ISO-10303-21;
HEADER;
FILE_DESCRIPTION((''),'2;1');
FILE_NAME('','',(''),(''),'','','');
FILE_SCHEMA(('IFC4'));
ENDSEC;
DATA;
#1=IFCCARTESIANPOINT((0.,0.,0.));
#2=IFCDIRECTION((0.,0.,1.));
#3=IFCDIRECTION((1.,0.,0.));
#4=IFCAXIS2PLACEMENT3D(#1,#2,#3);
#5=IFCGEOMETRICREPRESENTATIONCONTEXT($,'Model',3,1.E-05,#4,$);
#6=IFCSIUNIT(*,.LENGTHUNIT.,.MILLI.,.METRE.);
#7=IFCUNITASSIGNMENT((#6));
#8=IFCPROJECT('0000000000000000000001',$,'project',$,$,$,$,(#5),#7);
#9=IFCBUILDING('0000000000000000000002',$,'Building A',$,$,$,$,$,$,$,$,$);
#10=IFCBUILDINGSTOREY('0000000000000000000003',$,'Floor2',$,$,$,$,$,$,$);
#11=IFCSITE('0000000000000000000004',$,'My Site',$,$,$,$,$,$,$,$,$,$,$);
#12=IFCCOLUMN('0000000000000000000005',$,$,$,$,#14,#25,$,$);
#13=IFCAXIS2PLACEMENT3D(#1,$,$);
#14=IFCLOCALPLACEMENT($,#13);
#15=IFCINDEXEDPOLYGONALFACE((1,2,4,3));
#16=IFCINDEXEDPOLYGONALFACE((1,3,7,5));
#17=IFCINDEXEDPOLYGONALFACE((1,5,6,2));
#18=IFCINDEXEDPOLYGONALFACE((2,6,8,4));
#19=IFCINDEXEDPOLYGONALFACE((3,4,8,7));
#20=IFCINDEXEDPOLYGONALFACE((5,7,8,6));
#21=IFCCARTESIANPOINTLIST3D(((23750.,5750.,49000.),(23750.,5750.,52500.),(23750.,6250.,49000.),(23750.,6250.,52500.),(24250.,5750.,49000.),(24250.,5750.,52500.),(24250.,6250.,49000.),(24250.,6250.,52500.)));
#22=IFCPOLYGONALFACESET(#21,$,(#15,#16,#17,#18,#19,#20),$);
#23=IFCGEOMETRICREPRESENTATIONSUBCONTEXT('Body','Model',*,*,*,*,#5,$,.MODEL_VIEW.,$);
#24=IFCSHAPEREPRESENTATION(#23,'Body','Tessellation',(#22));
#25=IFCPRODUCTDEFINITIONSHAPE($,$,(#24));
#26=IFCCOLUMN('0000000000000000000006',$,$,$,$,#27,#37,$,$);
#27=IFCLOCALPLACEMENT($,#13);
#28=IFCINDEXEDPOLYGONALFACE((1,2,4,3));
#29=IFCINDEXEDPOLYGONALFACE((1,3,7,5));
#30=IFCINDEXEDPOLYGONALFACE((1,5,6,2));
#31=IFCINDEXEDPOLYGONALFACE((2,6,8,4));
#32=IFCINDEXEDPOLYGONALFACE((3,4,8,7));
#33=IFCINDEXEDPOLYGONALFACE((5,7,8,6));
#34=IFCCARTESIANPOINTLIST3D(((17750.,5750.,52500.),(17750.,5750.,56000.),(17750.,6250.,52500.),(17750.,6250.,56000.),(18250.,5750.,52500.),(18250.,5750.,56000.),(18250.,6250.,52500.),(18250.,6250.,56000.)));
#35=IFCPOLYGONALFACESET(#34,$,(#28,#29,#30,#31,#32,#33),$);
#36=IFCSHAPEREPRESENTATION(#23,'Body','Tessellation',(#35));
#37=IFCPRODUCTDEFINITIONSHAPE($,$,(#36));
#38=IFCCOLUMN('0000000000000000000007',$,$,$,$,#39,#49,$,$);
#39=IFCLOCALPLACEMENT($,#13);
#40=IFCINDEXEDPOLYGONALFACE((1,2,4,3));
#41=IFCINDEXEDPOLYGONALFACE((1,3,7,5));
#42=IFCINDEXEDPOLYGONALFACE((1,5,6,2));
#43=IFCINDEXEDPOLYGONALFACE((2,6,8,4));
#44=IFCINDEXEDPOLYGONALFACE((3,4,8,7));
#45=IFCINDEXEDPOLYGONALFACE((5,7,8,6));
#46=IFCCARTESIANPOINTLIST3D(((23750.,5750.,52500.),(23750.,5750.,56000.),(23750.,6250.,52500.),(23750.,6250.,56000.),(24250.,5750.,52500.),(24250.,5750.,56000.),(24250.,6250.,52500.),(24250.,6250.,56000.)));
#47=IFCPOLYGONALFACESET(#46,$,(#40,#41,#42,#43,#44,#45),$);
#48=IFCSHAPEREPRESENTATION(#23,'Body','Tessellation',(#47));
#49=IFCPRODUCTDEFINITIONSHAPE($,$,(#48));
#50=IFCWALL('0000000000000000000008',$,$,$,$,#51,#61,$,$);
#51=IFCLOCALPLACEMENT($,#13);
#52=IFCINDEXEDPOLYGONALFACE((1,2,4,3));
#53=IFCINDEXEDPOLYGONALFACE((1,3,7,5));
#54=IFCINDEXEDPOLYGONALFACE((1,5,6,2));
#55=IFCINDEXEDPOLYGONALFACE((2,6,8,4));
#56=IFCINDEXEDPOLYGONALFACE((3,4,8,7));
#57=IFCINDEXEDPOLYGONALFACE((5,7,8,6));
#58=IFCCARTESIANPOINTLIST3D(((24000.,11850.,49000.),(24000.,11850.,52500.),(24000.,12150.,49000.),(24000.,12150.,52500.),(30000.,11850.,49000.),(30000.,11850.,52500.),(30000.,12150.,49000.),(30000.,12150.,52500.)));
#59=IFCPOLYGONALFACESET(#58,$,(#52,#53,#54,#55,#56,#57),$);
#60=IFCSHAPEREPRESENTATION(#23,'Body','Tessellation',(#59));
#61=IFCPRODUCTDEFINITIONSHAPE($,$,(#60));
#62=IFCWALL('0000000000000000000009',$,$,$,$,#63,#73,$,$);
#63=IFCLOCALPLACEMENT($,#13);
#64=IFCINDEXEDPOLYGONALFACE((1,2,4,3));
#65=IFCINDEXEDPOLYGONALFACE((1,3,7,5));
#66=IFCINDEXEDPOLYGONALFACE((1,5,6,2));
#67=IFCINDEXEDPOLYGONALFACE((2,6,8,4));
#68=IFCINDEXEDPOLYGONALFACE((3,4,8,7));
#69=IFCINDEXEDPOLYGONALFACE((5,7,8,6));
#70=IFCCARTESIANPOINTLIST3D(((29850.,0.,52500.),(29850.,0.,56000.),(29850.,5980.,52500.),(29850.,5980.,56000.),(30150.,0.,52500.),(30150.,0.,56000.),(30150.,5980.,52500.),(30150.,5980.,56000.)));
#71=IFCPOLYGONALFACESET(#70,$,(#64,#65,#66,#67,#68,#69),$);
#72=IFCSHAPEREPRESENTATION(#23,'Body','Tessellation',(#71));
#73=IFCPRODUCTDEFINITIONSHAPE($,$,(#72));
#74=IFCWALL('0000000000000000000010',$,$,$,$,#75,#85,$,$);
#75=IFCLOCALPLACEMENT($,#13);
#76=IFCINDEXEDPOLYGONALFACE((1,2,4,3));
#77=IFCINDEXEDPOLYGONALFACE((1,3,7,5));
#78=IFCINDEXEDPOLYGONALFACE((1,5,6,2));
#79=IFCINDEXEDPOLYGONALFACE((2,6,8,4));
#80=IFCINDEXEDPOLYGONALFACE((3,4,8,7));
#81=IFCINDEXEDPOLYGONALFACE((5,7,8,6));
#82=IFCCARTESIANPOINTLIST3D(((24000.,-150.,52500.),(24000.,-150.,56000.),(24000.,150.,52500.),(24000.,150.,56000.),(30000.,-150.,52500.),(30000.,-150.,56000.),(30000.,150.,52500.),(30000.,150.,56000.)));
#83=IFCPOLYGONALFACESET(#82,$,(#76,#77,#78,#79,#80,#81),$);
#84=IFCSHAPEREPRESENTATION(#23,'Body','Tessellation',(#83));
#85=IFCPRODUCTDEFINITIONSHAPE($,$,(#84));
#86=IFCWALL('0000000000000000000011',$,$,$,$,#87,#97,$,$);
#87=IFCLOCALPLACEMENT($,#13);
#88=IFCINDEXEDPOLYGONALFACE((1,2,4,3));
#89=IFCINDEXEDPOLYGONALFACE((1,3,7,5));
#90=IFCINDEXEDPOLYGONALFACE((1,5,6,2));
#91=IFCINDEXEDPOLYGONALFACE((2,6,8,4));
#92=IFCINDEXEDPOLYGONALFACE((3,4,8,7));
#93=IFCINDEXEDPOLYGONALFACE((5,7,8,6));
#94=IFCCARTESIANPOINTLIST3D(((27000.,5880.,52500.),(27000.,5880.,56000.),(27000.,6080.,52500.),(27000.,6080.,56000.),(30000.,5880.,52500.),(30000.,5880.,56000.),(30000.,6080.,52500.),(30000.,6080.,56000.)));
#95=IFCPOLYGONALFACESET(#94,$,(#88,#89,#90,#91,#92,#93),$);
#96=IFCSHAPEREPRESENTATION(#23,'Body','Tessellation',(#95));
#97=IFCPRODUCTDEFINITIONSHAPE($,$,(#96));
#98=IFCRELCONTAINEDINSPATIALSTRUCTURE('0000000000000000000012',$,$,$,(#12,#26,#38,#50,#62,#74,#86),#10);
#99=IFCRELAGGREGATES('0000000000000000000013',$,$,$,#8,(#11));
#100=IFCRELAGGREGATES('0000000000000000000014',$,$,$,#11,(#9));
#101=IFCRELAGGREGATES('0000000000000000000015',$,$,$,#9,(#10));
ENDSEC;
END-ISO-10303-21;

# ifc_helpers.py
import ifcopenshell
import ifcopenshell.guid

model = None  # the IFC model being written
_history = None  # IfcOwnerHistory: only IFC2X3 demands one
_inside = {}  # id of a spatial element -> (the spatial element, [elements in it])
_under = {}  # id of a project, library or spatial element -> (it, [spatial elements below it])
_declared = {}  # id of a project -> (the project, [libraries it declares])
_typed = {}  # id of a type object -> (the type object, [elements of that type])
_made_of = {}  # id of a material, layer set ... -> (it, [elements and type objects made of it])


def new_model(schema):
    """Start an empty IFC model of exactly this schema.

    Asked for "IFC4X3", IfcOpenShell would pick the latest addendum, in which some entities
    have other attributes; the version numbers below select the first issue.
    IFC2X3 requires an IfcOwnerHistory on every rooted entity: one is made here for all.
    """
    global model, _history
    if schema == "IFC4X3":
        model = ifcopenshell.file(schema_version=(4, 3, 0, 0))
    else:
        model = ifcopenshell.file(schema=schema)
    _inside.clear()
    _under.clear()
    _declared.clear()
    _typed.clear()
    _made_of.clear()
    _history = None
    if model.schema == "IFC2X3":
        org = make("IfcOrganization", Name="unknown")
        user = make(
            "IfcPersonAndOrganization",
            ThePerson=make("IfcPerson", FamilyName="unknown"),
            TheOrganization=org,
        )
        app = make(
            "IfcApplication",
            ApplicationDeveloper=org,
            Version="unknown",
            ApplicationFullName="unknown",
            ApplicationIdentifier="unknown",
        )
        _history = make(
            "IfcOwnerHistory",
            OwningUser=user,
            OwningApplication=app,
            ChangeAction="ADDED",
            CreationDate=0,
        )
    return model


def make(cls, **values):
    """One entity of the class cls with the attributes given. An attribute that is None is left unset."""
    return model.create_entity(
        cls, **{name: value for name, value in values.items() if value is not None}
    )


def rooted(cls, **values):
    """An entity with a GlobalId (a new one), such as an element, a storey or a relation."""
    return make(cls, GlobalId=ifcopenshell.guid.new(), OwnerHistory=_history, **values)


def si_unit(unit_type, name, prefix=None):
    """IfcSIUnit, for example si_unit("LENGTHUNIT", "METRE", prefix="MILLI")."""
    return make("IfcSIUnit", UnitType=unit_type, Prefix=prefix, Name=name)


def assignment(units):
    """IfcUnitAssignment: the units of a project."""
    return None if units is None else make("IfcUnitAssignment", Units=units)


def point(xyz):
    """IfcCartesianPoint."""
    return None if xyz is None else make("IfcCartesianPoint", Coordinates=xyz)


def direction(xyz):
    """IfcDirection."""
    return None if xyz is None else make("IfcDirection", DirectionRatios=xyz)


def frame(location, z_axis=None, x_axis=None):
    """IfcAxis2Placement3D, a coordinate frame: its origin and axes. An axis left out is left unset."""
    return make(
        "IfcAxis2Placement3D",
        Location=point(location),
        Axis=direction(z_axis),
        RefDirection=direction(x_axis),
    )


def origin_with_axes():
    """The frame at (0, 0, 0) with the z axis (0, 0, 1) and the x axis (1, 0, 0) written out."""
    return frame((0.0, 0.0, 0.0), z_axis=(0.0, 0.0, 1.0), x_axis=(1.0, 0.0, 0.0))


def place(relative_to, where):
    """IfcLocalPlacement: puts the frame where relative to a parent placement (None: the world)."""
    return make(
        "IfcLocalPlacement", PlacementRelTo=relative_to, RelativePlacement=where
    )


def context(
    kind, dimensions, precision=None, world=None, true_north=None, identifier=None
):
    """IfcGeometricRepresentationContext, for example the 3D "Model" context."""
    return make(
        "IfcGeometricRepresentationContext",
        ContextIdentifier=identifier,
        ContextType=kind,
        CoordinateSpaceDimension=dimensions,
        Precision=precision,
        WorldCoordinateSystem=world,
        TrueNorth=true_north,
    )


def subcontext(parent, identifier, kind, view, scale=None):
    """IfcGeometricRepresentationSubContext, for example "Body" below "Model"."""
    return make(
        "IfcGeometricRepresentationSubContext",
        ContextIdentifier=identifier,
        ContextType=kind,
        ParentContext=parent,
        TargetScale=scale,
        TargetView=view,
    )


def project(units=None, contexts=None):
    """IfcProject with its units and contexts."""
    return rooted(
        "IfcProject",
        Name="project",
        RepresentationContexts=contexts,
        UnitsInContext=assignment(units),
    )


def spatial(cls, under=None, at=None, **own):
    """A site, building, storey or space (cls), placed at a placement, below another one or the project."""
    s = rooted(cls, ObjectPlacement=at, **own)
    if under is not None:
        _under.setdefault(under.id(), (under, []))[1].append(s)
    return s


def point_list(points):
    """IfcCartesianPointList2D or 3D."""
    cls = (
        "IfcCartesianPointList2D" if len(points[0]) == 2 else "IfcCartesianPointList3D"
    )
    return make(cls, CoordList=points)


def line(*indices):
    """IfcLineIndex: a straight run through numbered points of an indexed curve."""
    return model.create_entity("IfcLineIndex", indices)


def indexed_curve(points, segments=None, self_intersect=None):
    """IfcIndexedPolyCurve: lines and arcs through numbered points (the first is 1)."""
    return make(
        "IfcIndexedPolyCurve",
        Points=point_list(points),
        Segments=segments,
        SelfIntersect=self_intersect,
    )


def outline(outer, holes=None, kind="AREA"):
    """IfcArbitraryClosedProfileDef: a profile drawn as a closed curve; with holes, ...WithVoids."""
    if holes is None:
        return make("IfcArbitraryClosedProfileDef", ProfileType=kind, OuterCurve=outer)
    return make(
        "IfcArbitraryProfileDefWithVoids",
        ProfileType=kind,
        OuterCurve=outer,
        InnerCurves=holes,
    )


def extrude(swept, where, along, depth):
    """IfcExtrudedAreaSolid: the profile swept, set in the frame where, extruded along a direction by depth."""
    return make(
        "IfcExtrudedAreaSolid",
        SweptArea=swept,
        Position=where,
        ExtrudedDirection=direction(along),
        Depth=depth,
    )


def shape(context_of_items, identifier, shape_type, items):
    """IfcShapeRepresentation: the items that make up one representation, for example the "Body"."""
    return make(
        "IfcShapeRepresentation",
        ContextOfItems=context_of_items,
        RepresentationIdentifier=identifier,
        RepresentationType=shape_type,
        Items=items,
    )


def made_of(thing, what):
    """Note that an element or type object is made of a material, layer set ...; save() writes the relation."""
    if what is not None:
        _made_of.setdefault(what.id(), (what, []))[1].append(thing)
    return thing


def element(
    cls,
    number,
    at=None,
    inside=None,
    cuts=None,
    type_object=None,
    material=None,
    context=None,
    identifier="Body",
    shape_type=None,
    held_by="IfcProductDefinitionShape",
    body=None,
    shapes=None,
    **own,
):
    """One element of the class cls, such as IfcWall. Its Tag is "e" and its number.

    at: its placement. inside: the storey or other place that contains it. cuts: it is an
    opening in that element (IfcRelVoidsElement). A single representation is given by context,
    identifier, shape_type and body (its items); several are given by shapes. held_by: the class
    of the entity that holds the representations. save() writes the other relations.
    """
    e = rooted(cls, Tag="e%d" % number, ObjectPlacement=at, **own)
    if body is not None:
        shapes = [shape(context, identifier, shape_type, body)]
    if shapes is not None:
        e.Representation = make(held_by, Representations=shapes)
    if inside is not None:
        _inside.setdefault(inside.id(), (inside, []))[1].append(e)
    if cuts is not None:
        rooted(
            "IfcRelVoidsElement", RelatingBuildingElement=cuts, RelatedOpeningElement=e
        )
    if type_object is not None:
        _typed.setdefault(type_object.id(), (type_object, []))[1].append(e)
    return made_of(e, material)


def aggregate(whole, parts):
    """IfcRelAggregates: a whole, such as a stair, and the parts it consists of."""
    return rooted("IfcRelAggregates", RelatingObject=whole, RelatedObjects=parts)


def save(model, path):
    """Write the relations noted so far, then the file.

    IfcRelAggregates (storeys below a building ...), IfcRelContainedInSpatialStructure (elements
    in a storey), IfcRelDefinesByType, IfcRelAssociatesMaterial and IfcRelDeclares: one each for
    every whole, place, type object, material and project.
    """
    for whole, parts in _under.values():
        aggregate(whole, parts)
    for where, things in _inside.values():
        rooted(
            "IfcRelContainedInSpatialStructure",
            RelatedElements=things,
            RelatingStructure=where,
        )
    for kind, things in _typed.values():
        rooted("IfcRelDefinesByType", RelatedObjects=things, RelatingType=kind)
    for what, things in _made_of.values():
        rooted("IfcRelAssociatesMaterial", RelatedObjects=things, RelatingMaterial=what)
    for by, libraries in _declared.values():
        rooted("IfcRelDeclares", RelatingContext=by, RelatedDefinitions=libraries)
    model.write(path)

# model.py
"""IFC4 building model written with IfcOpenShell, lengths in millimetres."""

from ifc_helpers import new_model, si_unit, frame, origin_with_axes, place, context, subcontext, project, spatial, line, indexed_curve, outline, extrude, element, save


model = new_model("IFC4")

# Units and contexts
model_context = context("Model", 3, precision=1e-05, world=origin_with_axes())
body_context = subcontext(model_context, "Body", "Model", "MODEL_VIEW")
ifc_project = project(units=[si_unit("LENGTHUNIT", "METRE", prefix="MILLI")], contexts=[model_context])

# Site, building, storey
site = spatial("IfcSite", under=ifc_project, Name="My Site")
building = spatial("IfcBuilding", under=site, Name="Building A")
storey = spatial("IfcBuildingStorey", under=building, Name="Floor2")

# Columns
for number, where, z_axis, x_axis in (
    (1, (24000.0, 6000.0, 49000.0), (0.0, 0.0, 1.0), (1.0, 0.0, 0.0)),
    (2, (18000.0, 6000.0, 52500.0), (0.0, 0.0, 1.0), (1.0, 0.0, 0.0)),
    (3, (24000.0, 6000.0, 52500.0), (0.0, 0.0, 1.0), (1.0, 0.0, 0.0)),
):
    element("IfcColumn", number, at=place(None, frame(where, z_axis=z_axis, x_axis=x_axis)), inside=storey, context=body_context, shape_type="SweptSolid", body=[
        extrude(outline(indexed_curve([(-250.0, -250.0), (250.0, -250.0), (250.0, 250.0), (-250.0, 250.0)], segments=[line(1, 2, 3, 4, 1)])), origin_with_axes(), (0.0, 0.0, 1.0), 3500.0),
    ])

# Walls
wall_1_placement = place(None, frame((24000.0, 11850.0, 49000.0), z_axis=(0.0, 0.0, 1.0), x_axis=(1.0, 0.0, 0.0)))
element("IfcWall", 4, at=wall_1_placement, inside=storey, context=body_context, shape_type="SweptSolid", body=[
    extrude(outline(indexed_curve([(0.0, 0.0), (0.0, 300.0), (6000.0, 300.0), (6000.0, 0.0), (0.0, 0.0)], self_intersect=False)), origin_with_axes(), (0.0, 0.0, 1.0), 3500.0),
])
wall_2_placement = place(None, frame((29850.0, 5980.0, 52500.0), z_axis=(0.0, 0.0, 1.0), x_axis=(0.0, -1.0, 0.0)))
element("IfcWall", 5, at=wall_2_placement, inside=storey, context=body_context, shape_type="SweptSolid", body=[
    extrude(outline(indexed_curve([(0.0, 0.0), (0.0, 300.0), (5980.0, 300.0), (5980.0, 0.0), (0.0, 0.0)], self_intersect=False)), origin_with_axes(), (0.0, 0.0, 1.0), 3500.0),
])
wall_3_placement = place(None, frame((30000.0, 150.0, 52500.0), z_axis=(0.0, 0.0, 1.0), x_axis=(-1.0, 0.0, 0.0)))
element("IfcWall", 6, at=wall_3_placement, inside=storey, context=body_context, shape_type="SweptSolid", body=[
    extrude(outline(indexed_curve([(0.0, 0.0), (0.0, 300.0), (6000.0, 300.0), (6000.0, 0.0), (0.0, 0.0)], self_intersect=False)), origin_with_axes(), (0.0, 0.0, 1.0), 3500.0),
])
wall_4_placement = place(None, frame((27000.0, 5880.0, 52500.0), z_axis=(0.0, 0.0, 1.0), x_axis=(1.0, 0.0, 0.0)))
element("IfcWall", 7, at=wall_4_placement, inside=storey, context=body_context, shape_type="SweptSolid", body=[
    extrude(outline(indexed_curve([(0.0, 0.0), (0.0, 200.0), (3000.0, 200.0), (3000.0, 0.0), (0.0, 0.0)], self_intersect=False)), origin_with_axes(), (0.0, 0.0, 1.0), 3500.0),
])

save(model, "model.ifc")
